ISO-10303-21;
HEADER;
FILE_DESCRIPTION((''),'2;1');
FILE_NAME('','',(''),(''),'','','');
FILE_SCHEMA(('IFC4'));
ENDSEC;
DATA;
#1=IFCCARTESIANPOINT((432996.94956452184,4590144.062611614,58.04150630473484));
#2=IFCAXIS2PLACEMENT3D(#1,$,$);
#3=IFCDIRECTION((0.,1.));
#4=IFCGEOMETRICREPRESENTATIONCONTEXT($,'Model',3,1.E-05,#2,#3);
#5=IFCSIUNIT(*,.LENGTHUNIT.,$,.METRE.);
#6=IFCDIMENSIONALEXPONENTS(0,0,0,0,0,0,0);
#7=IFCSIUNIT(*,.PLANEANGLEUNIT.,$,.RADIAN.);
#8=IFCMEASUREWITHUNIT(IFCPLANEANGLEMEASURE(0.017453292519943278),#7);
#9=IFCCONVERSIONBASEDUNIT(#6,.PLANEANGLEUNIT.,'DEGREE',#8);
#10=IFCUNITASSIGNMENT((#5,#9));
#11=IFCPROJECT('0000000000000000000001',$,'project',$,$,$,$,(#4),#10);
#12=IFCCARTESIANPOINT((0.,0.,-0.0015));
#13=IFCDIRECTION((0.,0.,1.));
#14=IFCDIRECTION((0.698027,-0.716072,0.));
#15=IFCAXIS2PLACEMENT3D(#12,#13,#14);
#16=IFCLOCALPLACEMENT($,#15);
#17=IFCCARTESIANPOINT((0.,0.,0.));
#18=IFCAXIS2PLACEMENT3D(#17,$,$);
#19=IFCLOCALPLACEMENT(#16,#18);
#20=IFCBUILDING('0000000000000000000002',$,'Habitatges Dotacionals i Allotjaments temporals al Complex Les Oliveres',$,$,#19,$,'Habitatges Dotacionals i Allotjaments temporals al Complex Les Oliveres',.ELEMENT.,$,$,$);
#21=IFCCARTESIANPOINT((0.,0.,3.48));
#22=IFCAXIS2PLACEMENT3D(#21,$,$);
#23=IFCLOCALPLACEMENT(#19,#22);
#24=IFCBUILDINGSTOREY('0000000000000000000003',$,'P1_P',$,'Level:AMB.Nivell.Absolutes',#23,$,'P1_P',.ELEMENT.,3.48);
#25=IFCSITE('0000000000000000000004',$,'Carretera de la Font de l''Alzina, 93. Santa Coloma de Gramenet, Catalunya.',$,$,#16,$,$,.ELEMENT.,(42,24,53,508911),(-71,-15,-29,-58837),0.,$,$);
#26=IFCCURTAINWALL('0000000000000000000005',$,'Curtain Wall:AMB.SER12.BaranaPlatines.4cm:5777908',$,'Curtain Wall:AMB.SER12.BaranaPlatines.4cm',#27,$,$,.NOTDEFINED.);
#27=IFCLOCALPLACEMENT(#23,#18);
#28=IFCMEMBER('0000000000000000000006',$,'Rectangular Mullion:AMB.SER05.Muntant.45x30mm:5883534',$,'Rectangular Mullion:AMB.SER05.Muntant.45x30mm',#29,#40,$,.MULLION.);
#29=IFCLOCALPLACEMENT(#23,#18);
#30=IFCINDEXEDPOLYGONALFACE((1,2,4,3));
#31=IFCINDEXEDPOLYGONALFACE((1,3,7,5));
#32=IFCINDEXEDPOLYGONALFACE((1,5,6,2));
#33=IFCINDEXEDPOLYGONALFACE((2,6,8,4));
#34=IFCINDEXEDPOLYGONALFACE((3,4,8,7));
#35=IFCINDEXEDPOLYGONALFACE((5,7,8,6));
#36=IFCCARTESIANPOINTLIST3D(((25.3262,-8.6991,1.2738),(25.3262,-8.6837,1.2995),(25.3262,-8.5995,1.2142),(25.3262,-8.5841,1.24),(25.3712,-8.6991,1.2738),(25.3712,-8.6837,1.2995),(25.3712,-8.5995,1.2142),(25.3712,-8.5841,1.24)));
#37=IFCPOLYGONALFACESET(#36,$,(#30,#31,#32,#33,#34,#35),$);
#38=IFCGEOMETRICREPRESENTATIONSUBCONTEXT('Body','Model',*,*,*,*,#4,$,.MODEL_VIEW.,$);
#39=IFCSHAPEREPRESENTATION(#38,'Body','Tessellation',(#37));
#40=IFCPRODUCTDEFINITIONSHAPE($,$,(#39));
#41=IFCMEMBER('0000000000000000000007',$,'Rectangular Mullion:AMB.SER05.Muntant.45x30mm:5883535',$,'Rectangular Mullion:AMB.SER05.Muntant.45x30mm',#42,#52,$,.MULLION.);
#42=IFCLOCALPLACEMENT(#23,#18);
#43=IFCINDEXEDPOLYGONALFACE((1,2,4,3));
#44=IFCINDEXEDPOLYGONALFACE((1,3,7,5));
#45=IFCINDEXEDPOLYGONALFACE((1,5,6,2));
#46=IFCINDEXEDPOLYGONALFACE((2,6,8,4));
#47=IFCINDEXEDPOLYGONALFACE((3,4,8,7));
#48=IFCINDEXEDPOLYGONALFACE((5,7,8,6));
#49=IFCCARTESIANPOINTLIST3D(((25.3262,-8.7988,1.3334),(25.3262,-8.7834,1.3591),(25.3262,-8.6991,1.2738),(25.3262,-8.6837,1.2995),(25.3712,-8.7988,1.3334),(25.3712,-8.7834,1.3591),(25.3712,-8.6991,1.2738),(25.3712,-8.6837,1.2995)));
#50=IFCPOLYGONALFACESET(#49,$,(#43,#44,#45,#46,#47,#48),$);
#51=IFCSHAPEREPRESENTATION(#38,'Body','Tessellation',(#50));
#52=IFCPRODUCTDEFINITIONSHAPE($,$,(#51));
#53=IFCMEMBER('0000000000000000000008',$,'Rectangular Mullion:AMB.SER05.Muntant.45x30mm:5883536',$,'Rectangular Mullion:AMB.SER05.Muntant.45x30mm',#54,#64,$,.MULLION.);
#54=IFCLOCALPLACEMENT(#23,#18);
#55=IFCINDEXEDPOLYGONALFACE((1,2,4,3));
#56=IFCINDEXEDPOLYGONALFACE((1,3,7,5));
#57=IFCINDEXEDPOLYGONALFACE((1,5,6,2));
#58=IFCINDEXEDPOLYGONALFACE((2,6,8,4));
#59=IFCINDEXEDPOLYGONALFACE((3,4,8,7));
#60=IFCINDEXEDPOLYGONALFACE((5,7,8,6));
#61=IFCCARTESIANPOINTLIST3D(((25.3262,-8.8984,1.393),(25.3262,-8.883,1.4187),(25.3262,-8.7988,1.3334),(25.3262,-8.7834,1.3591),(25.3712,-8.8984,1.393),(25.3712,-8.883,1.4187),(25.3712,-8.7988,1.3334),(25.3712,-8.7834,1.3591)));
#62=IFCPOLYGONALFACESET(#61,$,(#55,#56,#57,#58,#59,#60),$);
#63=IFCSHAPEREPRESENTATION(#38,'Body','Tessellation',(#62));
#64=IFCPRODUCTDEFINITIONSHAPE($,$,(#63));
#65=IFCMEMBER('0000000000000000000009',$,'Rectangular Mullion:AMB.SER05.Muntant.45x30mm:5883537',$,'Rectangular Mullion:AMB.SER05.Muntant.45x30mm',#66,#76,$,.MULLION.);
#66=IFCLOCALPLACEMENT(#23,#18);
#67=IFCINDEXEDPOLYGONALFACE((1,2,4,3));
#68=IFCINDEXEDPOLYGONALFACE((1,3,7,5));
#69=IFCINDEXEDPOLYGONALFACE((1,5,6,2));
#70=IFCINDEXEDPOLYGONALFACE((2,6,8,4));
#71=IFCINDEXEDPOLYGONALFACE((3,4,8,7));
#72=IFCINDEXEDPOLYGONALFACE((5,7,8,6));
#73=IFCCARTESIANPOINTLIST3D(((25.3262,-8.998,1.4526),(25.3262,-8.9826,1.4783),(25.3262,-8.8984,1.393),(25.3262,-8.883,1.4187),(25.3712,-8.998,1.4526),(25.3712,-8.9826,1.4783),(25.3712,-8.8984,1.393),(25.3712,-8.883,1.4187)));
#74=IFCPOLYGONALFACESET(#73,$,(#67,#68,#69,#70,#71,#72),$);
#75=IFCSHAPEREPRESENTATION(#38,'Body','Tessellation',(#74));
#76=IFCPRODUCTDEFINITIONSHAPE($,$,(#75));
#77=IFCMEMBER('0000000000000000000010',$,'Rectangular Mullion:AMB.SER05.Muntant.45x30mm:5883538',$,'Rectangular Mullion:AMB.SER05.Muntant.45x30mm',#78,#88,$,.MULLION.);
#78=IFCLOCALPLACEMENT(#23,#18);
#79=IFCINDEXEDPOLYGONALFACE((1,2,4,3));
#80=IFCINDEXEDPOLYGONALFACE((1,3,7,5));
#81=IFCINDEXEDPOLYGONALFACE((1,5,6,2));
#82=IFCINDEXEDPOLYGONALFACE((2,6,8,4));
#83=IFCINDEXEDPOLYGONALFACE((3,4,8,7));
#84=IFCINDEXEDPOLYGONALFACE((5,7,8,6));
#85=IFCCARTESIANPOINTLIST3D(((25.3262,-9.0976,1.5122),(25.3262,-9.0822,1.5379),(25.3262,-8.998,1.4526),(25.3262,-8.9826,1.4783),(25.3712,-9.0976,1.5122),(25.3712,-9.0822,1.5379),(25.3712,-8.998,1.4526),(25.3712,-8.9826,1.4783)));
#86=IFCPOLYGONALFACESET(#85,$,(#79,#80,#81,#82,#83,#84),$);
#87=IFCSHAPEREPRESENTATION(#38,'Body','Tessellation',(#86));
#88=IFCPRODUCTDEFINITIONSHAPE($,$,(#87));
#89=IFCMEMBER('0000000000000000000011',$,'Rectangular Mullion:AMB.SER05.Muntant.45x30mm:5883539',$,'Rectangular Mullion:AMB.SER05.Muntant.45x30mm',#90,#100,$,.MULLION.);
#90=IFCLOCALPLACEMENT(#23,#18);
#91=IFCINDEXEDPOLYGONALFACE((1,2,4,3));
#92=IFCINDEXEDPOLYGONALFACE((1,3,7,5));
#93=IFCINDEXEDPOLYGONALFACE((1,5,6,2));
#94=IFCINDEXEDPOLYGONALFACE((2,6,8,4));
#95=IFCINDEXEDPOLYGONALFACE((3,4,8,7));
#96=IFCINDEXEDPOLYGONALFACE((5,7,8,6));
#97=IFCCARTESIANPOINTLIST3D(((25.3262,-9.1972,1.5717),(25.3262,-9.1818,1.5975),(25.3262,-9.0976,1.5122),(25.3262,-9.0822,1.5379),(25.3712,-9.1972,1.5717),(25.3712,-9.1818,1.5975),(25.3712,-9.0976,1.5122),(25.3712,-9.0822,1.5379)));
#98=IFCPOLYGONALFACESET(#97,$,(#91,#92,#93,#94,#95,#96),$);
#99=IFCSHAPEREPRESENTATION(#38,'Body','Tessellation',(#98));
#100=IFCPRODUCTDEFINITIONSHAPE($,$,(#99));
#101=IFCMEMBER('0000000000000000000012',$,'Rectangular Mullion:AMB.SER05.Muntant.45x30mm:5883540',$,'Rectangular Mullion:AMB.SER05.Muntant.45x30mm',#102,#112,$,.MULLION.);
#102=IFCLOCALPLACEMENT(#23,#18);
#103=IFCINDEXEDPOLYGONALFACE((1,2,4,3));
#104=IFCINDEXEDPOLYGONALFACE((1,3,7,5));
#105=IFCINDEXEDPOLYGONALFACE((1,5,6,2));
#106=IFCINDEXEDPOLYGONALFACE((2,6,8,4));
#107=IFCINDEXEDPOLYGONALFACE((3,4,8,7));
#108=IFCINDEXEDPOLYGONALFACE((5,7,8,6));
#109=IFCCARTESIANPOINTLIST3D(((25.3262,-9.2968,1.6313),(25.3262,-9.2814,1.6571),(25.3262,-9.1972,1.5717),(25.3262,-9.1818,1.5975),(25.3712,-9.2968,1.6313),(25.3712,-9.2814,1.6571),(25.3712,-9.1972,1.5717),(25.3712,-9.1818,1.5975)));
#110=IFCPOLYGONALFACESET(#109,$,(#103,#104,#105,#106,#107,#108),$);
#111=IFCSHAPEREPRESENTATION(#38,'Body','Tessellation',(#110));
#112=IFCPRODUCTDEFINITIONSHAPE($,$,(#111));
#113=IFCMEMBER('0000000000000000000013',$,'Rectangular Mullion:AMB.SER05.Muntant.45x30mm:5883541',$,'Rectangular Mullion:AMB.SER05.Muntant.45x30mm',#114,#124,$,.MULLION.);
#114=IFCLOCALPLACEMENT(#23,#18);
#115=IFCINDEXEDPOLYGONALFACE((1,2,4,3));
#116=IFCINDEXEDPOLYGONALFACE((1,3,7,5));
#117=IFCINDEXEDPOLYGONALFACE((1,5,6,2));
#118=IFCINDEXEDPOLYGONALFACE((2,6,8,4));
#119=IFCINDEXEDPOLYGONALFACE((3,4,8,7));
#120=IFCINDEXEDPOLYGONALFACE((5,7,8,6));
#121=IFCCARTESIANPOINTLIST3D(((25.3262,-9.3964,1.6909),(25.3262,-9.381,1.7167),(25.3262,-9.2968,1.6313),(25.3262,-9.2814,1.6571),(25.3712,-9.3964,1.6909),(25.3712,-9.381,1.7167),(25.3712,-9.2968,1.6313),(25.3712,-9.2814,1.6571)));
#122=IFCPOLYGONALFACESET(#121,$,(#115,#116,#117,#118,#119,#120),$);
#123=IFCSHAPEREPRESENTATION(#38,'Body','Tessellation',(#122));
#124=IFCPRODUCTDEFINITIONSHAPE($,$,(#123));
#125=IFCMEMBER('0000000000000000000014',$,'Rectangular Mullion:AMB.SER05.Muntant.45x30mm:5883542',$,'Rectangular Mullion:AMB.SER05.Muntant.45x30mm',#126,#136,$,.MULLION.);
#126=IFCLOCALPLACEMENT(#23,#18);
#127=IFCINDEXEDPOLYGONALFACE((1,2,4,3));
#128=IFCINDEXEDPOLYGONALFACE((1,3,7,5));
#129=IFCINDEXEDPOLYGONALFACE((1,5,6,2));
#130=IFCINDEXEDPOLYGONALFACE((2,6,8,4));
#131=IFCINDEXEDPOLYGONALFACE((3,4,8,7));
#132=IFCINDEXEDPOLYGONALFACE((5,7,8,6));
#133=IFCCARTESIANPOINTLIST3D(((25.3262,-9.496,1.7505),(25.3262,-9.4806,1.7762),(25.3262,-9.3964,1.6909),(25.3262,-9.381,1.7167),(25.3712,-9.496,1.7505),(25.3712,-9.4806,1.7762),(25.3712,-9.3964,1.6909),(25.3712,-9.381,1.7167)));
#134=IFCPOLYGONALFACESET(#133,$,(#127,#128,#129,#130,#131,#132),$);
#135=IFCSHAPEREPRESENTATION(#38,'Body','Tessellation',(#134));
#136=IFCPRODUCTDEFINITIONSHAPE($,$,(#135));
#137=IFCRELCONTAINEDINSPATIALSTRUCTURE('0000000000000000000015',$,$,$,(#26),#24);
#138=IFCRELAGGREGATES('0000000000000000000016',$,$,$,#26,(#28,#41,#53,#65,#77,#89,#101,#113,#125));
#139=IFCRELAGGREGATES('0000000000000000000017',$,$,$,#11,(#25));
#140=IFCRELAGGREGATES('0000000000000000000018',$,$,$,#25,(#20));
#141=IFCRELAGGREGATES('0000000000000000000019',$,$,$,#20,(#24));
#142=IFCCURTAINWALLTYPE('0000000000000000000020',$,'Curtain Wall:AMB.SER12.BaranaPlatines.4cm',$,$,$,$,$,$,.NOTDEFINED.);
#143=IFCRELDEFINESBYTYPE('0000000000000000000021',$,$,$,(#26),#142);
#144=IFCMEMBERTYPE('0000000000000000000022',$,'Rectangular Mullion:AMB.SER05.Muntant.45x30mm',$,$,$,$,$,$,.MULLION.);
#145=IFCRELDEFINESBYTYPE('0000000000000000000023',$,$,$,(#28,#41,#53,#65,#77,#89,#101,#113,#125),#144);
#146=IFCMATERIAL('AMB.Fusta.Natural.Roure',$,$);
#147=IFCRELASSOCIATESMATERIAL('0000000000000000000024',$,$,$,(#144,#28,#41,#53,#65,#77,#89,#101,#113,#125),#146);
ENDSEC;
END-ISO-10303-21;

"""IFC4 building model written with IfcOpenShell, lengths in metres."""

from ifc_helpers import new_model, entity, si_unit, converted_unit, direction, frame, origin, place, context, subcontext, project, spatial, indexed_curve, outline, extrude, source, transform, mapped, material, type_object, type_shapes, element, aggregate, save


model = new_model("IFC4")

# Units and contexts
model_context = context("Model", 3, precision=1e-05, world=frame((432996.94956452184, 4590144.062611614, 58.04150630473484)), true_north=direction((0.0, 1.0)))
body_context = subcontext(model_context, "Body", "Model", "MODEL_VIEW")
ifc_project = project(units=[si_unit("LENGTHUNIT", "METRE"), converted_unit("PLANEANGLEUNIT", "DEGREE", entity("IfcPlaneAngleMeasure", 0.017453292519943278), si_unit("PLANEANGLEUNIT", "RADIAN"), dimensions=[0, 0, 0, 0, 0, 0, 0])], contexts=[model_context])

# Site, building, storey
site_placement = place(None, frame((0.0, 0.0, -0.0015), z_axis=(0.0, 0.0, 1.0), x_axis=(0.698027, -0.716072, 0.0)))
site = spatial("IfcSite", under=ifc_project, at=site_placement, Name="Carretera de la Font de l'Alzina, 93. Santa Coloma de Gramenet, Catalunya.", CompositionType="ELEMENT", RefLatitude=(42, 24, 53, 508911), RefLongitude=(-71, -15, -29, -58837), RefElevation=0.0)
building_placement = place(site_placement, origin())
building = spatial("IfcBuilding", under=site, at=building_placement, Name="Habitatges Dotacionals i Allotjaments temporals al Complex Les Oliveres", LongName="Habitatges Dotacionals i Allotjaments temporals al Complex Les Oliveres", CompositionType="ELEMENT")
storey_placement = place(building_placement, frame((0.0, 0.0, 3.48)))
storey = spatial("IfcBuildingStorey", under=building, at=storey_placement, Name="P1_P", ObjectType="Level:AMB.Nivell.Absolutes", LongName="P1_P", CompositionType="ELEMENT", Elevation=3.48)

# Curtain wall, members
curtain_wall_type = type_object("IfcCurtainWallType", Name="Curtain Wall:AMB.SER12.BaranaPlatines.4cm", PredefinedType="NOTDEFINED")
curtain_wall_1_placement = place(storey_placement, frame((0.0, 0.0, -3.48)))
curtain_wall_1 = element("IfcCurtainWall", 1, at=curtain_wall_1_placement, inside=storey, type_object=curtain_wall_type, Name="Curtain Wall:AMB.SER12.BaranaPlatines.4cm:5777908", ObjectType="Curtain Wall:AMB.SER12.BaranaPlatines.4cm", PredefinedType="NOTDEFINED")
ifc_material_1 = material(Name="AMB.Fusta.Natural.Roure")
member_type_1 = type_object("IfcMemberType", Name="Rectangular Mullion:AMB.SER05.Muntant.45x30mm", PredefinedType="MULLION", material=ifc_material_1)
shared_shape_1 = source(origin(), body_context, "Body", "SweptSolid", [
    extrude(outline(indexed_curve([(-0.015, -0.0225), (0.015, -0.0225), (0.015, 0.0225), (-0.015, 0.0225), (-0.015, -0.0225)], self_intersect=False)), frame((-0.015, -0.02, -0.1161), z_axis=(0.0, 0.0, 1.0), x_axis=(-1.0, 0.0, 0.0)), (0.0, 0.0, 1.0), 0.1161),
])
type_shapes(member_type_1, [shared_shape_1])
member_1_placement = place(curtain_wall_1_placement, frame((25.3287, -8.6837, 4.7795), z_axis=(0.0, -0.858168, 0.513369), x_axis=(0.0, 0.513369, 0.858168)))
member_1 = element("IfcMember", 2, at=member_1_placement, type_object=member_type_1, material=ifc_material_1, Name="Rectangular Mullion:AMB.SER05.Muntant.45x30mm:5883534", ObjectType="Rectangular Mullion:AMB.SER05.Muntant.45x30mm", PredefinedType="MULLION", context=body_context, shape_type="MappedRepresentation", body=[
    mapped(shared_shape_1, transform((0.0, 0.0, 0.0), scale=1.0)),
])
member_2_placement = place(curtain_wall_1_placement, frame((25.3287, -8.7834, 4.8391), z_axis=(0.0, -0.858168, 0.513369), x_axis=(0.0, 0.513369, 0.858168)))
member_2 = element("IfcMember", 3, at=member_2_placement, type_object=member_type_1, material=ifc_material_1, Name="Rectangular Mullion:AMB.SER05.Muntant.45x30mm:5883535", ObjectType="Rectangular Mullion:AMB.SER05.Muntant.45x30mm", PredefinedType="MULLION", context=body_context, shape_type="MappedRepresentation", body=[
    mapped(shared_shape_1, transform((0.0, 0.0, 0.0), scale=1.0)),
])
member_3_placement = place(curtain_wall_1_placement, frame((25.3287, -8.883, 4.8987), z_axis=(0.0, -0.858168, 0.513369), x_axis=(0.0, 0.513369, 0.858168)))
member_3 = element("IfcMember", 4, at=member_3_placement, type_object=member_type_1, material=ifc_material_1, Name="Rectangular Mullion:AMB.SER05.Muntant.45x30mm:5883536", ObjectType="Rectangular Mullion:AMB.SER05.Muntant.45x30mm", PredefinedType="MULLION", context=body_context, shape_type="MappedRepresentation", body=[
    mapped(shared_shape_1, transform((0.0, 0.0, 0.0), scale=1.0)),
])
member_4_placement = place(curtain_wall_1_placement, frame((25.3287, -8.9826, 4.9583), z_axis=(0.0, -0.858168, 0.513369), x_axis=(0.0, 0.513369, 0.858168)))
member_4 = element("IfcMember", 5, at=member_4_placement, type_object=member_type_1, material=ifc_material_1, Name="Rectangular Mullion:AMB.SER05.Muntant.45x30mm:5883537", ObjectType="Rectangular Mullion:AMB.SER05.Muntant.45x30mm", PredefinedType="MULLION", context=body_context, shape_type="MappedRepresentation", body=[
    mapped(shared_shape_1, transform((0.0, 0.0, 0.0), scale=1.0)),
])
member_5_placement = place(curtain_wall_1_placement, frame((25.3287, -9.0822, 5.0179), z_axis=(0.0, -0.858168, 0.513369), x_axis=(0.0, 0.513369, 0.858168)))
member_5 = element("IfcMember", 6, at=member_5_placement, type_object=member_type_1, material=ifc_material_1, Name="Rectangular Mullion:AMB.SER05.Muntant.45x30mm:5883538", ObjectType="Rectangular Mullion:AMB.SER05.Muntant.45x30mm", PredefinedType="MULLION", context=body_context, shape_type="MappedRepresentation", body=[
    mapped(shared_shape_1, transform((0.0, 0.0, 0.0), scale=1.0)),
])
member_6_placement = place(curtain_wall_1_placement, frame((25.3287, -9.1818, 5.0775), z_axis=(0.0, -0.858168, 0.513369), x_axis=(0.0, 0.513369, 0.858168)))
member_6 = element("IfcMember", 7, at=member_6_placement, type_object=member_type_1, material=ifc_material_1, Name="Rectangular Mullion:AMB.SER05.Muntant.45x30mm:5883539", ObjectType="Rectangular Mullion:AMB.SER05.Muntant.45x30mm", PredefinedType="MULLION", context=body_context, shape_type="MappedRepresentation", body=[
    mapped(shared_shape_1, transform((0.0, 0.0, 0.0), scale=1.0)),
])
member_7_placement = place(curtain_wall_1_placement, frame((25.3287, -9.2814, 5.1371), z_axis=(0.0, -0.858168, 0.513369), x_axis=(0.0, 0.513369, 0.858168)))
member_7 = element("IfcMember", 8, at=member_7_placement, type_object=member_type_1, material=ifc_material_1, Name="Rectangular Mullion:AMB.SER05.Muntant.45x30mm:5883540", ObjectType="Rectangular Mullion:AMB.SER05.Muntant.45x30mm", PredefinedType="MULLION", context=body_context, shape_type="MappedRepresentation", body=[
    mapped(shared_shape_1, transform((0.0, 0.0, 0.0), scale=1.0)),
])
member_8_placement = place(curtain_wall_1_placement, frame((25.3287, -9.381, 5.1967), z_axis=(0.0, -0.858168, 0.513369), x_axis=(0.0, 0.513369, 0.858168)))
member_8 = element("IfcMember", 9, at=member_8_placement, type_object=member_type_1, material=ifc_material_1, Name="Rectangular Mullion:AMB.SER05.Muntant.45x30mm:5883541", ObjectType="Rectangular Mullion:AMB.SER05.Muntant.45x30mm", PredefinedType="MULLION", context=body_context, shape_type="MappedRepresentation", body=[
    mapped(shared_shape_1, transform((0.0, 0.0, 0.0), scale=1.0)),
])
member_9_placement = place(curtain_wall_1_placement, frame((25.3287, -9.4806, 5.2562), z_axis=(0.0, -0.858168, 0.513369), x_axis=(0.0, 0.513369, 0.858168)))
member_9 = element("IfcMember", 10, at=member_9_placement, type_object=member_type_1, material=ifc_material_1, Name="Rectangular Mullion:AMB.SER05.Muntant.45x30mm:5883542", ObjectType="Rectangular Mullion:AMB.SER05.Muntant.45x30mm", PredefinedType="MULLION", context=body_context, shape_type="MappedRepresentation", body=[
    mapped(shared_shape_1, transform((0.0, 0.0, 0.0), scale=1.0)),
])
aggregate(curtain_wall_1, [member_1, member_2, member_3, member_4, member_5, member_6, member_7, member_8, member_9])

save(model, "model.ifc")
